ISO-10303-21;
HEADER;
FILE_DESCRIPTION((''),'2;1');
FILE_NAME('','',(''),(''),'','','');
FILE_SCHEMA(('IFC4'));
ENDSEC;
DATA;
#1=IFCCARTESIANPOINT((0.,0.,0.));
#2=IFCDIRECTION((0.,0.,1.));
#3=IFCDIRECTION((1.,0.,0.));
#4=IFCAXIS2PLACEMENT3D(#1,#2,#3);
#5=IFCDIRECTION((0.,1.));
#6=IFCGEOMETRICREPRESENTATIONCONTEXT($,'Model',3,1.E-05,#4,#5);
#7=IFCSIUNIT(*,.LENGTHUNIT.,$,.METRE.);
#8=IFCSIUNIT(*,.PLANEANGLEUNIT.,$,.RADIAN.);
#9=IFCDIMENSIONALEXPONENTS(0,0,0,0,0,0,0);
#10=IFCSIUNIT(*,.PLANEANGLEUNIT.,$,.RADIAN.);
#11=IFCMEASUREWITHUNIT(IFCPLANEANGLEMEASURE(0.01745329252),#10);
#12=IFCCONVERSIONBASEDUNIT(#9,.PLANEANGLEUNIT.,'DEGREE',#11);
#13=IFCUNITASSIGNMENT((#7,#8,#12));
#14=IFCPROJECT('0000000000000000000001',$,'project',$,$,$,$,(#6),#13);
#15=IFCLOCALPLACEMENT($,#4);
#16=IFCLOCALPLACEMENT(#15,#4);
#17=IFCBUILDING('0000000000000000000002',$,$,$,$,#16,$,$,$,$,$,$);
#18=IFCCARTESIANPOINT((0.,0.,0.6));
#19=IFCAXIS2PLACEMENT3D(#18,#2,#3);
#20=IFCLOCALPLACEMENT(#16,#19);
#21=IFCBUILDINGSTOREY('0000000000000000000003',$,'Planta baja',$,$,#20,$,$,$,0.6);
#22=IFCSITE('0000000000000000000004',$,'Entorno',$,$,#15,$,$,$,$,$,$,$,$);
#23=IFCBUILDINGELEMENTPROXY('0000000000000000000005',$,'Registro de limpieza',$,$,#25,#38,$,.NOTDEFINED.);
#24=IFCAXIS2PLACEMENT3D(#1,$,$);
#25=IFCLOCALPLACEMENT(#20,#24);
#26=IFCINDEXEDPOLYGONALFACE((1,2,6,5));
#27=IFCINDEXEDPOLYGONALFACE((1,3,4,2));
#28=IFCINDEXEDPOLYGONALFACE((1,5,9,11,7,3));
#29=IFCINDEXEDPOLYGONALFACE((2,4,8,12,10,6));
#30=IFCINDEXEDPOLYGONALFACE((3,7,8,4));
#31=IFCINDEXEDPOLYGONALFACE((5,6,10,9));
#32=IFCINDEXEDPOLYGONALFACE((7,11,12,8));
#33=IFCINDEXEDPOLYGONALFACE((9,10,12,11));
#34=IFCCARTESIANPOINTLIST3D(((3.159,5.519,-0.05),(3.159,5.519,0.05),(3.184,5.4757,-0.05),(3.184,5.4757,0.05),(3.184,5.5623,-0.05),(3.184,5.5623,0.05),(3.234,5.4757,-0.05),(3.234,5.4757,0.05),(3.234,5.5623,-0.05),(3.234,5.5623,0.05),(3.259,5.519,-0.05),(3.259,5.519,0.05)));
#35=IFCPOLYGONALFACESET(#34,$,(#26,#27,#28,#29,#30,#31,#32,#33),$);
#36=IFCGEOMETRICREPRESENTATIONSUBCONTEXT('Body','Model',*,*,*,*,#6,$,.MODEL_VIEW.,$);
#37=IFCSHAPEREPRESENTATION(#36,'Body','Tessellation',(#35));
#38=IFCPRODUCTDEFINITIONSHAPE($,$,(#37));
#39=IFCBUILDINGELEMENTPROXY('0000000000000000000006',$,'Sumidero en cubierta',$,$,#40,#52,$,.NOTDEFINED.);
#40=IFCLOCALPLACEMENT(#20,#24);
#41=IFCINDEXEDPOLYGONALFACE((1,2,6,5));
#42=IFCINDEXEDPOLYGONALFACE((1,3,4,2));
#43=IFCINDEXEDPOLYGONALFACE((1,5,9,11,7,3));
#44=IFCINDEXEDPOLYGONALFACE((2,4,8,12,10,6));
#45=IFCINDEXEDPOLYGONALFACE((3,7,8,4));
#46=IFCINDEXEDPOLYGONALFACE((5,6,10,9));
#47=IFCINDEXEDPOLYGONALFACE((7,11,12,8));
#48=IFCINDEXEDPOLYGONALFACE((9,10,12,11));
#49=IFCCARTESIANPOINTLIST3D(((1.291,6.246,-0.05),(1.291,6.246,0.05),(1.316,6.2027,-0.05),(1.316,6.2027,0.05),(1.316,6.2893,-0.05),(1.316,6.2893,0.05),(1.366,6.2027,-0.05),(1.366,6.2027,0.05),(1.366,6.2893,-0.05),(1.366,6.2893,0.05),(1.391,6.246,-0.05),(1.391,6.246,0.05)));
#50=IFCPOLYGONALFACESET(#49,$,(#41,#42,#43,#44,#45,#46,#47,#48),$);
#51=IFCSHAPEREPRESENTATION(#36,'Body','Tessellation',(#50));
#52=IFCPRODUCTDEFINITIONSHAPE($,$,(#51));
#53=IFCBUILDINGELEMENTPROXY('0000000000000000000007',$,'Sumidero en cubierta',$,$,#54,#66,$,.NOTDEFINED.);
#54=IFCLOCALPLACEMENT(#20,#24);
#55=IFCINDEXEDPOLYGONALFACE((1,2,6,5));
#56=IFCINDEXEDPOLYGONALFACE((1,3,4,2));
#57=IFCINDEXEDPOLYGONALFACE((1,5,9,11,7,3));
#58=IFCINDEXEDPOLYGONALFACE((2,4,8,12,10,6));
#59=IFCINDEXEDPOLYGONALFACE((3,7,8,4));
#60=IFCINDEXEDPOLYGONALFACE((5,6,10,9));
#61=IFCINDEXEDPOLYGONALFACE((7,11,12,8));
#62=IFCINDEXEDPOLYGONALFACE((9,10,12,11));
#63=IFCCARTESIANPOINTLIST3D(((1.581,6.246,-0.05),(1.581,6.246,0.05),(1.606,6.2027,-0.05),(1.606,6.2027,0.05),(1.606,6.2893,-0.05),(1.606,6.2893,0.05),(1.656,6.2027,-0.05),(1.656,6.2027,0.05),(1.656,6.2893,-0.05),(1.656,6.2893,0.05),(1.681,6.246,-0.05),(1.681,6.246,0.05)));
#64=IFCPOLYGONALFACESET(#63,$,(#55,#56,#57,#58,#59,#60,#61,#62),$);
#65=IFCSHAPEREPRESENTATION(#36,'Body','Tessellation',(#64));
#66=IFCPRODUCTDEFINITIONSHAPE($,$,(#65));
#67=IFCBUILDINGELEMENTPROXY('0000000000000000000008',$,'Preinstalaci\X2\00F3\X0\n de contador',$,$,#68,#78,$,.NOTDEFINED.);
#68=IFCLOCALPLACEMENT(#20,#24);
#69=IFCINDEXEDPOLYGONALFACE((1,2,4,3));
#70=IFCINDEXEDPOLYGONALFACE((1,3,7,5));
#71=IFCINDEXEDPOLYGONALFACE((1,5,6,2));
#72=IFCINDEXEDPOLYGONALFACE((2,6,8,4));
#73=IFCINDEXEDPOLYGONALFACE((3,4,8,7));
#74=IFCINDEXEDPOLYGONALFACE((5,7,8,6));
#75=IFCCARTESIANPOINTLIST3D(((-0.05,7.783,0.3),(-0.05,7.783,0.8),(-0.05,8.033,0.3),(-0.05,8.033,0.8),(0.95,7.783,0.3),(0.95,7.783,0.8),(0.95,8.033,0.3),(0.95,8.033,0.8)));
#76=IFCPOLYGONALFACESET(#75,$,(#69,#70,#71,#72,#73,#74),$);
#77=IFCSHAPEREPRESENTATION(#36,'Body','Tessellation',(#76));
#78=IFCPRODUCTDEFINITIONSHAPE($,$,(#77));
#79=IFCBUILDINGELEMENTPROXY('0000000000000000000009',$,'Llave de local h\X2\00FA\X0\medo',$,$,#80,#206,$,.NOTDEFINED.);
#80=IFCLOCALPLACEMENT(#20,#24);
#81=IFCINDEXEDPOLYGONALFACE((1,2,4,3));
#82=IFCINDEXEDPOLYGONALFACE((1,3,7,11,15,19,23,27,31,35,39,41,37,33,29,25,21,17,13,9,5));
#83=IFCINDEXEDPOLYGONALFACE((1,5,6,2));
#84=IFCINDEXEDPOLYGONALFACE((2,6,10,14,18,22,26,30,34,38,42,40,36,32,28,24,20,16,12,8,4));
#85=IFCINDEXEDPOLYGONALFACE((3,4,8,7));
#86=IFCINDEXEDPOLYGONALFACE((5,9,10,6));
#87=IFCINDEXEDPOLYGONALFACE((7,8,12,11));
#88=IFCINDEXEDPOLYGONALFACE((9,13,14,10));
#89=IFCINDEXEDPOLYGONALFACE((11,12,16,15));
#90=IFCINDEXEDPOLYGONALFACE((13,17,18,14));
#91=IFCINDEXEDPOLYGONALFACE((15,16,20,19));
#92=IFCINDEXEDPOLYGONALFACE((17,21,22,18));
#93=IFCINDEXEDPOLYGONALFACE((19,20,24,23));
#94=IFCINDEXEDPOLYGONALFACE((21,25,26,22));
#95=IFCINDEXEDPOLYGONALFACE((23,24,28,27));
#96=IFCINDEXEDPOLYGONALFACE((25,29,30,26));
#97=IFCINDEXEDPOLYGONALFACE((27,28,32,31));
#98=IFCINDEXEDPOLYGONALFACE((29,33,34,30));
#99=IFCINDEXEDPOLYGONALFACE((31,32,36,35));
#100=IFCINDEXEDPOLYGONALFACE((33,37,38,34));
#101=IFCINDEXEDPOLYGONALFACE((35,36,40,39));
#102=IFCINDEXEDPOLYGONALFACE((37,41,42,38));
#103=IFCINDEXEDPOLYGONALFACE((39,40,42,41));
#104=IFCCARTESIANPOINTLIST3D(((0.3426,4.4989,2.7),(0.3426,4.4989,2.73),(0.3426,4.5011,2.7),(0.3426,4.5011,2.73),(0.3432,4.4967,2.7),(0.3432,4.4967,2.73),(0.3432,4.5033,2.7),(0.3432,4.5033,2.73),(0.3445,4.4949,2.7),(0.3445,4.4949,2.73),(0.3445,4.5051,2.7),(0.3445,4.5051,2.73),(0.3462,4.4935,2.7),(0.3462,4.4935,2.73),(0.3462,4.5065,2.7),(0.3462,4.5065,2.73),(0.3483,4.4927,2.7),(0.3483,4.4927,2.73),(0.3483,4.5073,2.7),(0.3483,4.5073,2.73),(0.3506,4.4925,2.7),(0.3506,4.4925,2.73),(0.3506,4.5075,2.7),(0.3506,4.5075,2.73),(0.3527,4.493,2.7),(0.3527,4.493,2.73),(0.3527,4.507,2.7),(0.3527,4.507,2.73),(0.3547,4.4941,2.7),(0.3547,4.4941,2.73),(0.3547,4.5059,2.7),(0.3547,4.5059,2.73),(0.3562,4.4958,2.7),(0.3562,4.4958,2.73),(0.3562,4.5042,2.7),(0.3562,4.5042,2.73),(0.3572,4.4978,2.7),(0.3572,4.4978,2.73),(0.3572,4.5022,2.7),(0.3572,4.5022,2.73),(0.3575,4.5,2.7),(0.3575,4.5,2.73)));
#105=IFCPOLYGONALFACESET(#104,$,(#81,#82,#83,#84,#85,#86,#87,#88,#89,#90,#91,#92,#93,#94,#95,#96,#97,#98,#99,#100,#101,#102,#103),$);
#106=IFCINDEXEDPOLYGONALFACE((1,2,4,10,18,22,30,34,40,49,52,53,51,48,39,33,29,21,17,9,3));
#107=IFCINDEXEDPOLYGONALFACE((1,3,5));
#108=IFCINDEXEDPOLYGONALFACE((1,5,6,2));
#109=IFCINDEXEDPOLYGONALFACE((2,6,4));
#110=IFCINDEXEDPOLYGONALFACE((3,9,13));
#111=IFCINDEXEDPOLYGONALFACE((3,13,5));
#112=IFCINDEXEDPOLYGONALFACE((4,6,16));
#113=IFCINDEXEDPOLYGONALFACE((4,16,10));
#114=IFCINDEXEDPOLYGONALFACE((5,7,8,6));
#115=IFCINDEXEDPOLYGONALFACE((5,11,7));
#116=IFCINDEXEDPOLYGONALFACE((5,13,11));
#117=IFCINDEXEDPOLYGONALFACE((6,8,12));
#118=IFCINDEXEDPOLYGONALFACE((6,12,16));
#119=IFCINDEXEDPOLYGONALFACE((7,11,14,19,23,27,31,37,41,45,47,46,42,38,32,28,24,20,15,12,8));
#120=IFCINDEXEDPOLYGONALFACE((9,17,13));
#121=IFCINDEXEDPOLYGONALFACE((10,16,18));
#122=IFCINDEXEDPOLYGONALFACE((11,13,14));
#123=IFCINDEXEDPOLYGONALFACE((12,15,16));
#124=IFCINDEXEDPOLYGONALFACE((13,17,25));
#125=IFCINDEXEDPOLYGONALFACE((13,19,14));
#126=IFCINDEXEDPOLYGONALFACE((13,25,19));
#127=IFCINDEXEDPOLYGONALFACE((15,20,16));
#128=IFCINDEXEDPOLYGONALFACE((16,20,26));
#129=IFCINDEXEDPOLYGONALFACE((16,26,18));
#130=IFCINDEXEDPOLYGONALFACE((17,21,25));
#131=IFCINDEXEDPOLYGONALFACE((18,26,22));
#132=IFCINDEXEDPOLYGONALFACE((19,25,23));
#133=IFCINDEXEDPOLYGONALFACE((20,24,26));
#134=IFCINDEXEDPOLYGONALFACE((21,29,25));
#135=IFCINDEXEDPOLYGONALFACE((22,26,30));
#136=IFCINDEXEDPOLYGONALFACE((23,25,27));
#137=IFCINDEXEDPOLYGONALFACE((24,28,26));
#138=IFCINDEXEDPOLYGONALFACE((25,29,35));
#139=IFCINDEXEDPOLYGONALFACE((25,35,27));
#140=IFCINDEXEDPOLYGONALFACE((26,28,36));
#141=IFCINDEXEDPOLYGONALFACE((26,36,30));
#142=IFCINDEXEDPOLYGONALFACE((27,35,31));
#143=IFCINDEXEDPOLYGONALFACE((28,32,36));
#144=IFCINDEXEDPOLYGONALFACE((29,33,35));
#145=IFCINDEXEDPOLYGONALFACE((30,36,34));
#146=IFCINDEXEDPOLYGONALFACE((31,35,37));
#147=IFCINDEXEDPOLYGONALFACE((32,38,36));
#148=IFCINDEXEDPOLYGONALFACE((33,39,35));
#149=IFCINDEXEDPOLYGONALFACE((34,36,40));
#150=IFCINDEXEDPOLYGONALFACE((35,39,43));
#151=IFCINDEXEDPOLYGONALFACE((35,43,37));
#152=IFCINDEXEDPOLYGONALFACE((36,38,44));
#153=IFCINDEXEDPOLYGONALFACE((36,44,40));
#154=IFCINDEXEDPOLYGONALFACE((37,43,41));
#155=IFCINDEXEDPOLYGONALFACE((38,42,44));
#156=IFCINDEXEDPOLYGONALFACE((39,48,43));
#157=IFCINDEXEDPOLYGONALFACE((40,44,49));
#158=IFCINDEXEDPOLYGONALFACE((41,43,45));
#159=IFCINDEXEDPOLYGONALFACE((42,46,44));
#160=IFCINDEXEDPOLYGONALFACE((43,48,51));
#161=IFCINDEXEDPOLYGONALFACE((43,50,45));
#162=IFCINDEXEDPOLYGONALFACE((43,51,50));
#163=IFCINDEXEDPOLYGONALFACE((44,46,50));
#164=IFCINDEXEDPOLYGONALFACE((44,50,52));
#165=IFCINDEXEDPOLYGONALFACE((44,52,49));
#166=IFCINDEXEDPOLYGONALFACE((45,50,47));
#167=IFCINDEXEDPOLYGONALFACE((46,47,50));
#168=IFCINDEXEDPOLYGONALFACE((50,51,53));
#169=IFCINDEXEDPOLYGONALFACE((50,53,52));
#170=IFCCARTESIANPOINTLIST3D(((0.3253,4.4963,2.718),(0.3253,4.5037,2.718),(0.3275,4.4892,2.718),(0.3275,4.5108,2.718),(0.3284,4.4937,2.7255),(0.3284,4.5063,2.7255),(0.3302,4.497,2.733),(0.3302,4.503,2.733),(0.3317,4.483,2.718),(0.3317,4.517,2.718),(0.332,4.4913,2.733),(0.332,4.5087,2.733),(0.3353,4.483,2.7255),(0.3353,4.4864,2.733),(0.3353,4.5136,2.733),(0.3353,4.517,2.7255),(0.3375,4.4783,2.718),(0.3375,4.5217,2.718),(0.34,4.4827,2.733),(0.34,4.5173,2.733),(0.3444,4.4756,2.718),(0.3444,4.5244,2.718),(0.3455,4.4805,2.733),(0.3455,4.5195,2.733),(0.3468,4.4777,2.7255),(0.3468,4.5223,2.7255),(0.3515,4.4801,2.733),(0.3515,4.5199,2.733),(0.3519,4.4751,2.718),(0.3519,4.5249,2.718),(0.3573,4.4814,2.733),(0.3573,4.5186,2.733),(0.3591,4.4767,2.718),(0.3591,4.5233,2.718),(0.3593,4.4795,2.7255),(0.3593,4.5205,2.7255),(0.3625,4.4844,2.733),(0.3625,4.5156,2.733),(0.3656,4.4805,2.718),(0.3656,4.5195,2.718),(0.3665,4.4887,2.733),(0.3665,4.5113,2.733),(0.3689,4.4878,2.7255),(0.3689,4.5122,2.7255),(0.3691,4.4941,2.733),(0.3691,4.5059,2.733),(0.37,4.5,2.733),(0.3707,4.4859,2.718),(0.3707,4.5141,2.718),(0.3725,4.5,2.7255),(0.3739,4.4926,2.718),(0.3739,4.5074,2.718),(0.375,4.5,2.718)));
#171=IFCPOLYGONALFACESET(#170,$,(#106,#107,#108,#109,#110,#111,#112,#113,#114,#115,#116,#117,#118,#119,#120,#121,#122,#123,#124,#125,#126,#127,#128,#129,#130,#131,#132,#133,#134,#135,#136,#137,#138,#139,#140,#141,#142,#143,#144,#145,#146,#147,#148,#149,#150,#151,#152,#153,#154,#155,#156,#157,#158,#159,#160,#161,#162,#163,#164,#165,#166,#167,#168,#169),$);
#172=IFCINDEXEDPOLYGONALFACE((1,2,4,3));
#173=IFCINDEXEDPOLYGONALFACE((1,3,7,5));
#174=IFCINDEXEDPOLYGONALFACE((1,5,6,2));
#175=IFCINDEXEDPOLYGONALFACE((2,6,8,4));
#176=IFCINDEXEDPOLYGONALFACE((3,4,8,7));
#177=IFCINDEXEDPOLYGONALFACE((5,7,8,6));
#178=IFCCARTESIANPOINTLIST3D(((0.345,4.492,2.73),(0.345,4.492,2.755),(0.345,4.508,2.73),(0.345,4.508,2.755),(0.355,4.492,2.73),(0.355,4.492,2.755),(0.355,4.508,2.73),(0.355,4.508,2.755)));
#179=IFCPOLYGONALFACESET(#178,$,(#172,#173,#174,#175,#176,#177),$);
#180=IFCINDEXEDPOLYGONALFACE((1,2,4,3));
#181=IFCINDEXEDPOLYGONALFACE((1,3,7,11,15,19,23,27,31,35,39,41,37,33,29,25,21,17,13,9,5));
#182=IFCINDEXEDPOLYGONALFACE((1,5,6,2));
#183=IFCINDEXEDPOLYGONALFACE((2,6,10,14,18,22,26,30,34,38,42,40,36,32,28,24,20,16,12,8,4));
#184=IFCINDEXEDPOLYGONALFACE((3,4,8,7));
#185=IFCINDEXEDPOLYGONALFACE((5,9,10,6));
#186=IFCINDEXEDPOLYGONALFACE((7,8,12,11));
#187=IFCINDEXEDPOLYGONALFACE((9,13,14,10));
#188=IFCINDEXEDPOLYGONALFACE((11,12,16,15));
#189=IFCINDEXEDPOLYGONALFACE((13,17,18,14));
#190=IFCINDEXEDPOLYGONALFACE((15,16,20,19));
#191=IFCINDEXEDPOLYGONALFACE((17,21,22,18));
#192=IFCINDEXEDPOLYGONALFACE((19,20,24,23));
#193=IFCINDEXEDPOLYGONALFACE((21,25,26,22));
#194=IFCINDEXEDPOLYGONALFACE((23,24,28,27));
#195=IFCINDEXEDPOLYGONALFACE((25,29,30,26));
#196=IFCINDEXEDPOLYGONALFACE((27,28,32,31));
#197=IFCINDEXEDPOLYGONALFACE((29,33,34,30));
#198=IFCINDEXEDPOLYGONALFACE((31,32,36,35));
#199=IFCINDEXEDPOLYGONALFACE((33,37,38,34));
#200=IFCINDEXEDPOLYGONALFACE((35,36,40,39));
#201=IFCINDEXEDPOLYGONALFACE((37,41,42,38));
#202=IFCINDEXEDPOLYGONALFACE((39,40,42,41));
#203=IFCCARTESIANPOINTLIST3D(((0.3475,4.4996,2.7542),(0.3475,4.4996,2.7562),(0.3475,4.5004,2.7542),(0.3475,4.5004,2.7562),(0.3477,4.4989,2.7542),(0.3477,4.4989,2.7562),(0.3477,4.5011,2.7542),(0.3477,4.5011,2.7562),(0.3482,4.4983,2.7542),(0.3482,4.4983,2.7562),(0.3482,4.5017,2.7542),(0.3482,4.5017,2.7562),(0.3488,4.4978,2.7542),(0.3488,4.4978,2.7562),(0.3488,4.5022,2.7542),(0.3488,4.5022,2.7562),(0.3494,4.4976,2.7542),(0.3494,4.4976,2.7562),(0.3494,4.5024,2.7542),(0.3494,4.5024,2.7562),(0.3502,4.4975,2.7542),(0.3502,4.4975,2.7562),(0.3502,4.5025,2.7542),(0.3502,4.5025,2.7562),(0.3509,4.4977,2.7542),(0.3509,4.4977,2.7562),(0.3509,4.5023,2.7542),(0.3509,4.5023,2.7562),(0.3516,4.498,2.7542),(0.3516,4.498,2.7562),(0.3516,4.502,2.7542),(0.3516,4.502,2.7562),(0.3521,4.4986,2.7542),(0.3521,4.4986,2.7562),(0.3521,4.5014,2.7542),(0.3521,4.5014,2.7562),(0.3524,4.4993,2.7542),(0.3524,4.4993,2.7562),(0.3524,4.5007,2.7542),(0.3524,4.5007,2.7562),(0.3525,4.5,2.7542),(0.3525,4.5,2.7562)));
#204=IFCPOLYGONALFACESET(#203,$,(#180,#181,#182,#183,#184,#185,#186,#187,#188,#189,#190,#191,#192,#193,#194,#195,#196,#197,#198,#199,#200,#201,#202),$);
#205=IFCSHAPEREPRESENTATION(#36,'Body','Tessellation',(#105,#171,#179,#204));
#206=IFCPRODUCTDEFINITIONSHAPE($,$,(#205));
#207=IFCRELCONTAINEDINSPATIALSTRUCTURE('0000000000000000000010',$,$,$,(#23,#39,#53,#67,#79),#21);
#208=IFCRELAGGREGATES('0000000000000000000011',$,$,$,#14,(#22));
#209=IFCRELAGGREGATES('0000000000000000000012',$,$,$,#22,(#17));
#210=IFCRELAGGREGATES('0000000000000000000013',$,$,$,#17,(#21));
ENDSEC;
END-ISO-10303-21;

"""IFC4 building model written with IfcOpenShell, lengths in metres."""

from ifc_helpers import new_model, entity, si_unit, converted_unit, direction, frame, origin_with_axes, place, context, subcontext, project, spatial, polyline, outline, extrude, source, transform, mapped, element, save


model = new_model("IFC4")

# Units and contexts
model_context = context("Model", 3, precision=1e-05, world=origin_with_axes(), true_north=direction((0.0, 1.0)))
body_context = subcontext(model_context, "Body", "Model", "MODEL_VIEW")
ifc_project = project(units=[si_unit("LENGTHUNIT", "METRE"), si_unit("PLANEANGLEUNIT", "RADIAN"), converted_unit("PLANEANGLEUNIT", "DEGREE", entity("IfcPlaneAngleMeasure", 0.01745329252), si_unit("PLANEANGLEUNIT", "RADIAN"), dimensions=[0, 0, 0, 0, 0, 0, 0])], contexts=[model_context])

# Site, building, storey
site_placement = place(None, origin_with_axes())
site = spatial("IfcSite", under=ifc_project, at=site_placement, Name="Entorno")
building_placement = place(site_placement, origin_with_axes())
building = spatial("IfcBuilding", under=site, at=building_placement)
storey_placement = place(building_placement, frame((0.0, 0.0, 0.6), z_axis=(0.0, 0.0, 1.0), x_axis=(1.0, 0.0, 0.0)))
storey = spatial("IfcBuildingStorey", under=building, at=storey_placement, Name="Planta baja", Elevation=0.6)

# Building element proxies
shared_shape_1 = source(origin_with_axes(), body_context, "Body", "SolidModel", [
    extrude(outline(polyline([(0.05, 0.0), (0.025, 0.0433), (-0.025, 0.0433), (-0.05, 0.0), (-0.025, -0.0433), (0.025, -0.0433), (0.05, 0.0)])), frame((0.0, 0.0, -0.05), z_axis=(0.0, 0.0, 1.0), x_axis=(1.0, 0.0, 0.0)), (0.0, 0.0, 1.0), 0.1),
])
proxy_1_placement = place(storey_placement, frame((0.0, 0.0, -0.6), z_axis=(0.0, 0.0, 1.0), x_axis=(1.0, 0.0, 0.0)))
element("IfcBuildingElementProxy", 1, at=proxy_1_placement, inside=storey, Name="Registro de limpieza", PredefinedType="NOTDEFINED", context=body_context, shape_type="Brep", body=[
    mapped(shared_shape_1, transform((3.209, 5.519, 0.6), x_axis=(1.0, 0.0, 0.0), y_axis=(0.0, 1.0, 0.0), z_axis=(0.0, 0.0, 1.0))),
])
shared_shape_2 = source(origin_with_axes(), body_context, "Body", "SolidModel", [
    extrude(outline(polyline([(0.05, 0.0), (0.025, 0.0433), (-0.025, 0.0433), (-0.05, 0.0), (-0.025, -0.0433), (0.025, -0.0433), (0.05, 0.0)])), frame((0.0, 0.0, -0.05), z_axis=(0.0, 0.0, 1.0), x_axis=(1.0, 0.0, 0.0)), (0.0, 0.0, 1.0), 0.1),
])
proxy_2_placement = place(storey_placement, frame((0.0, 0.0, -0.6), z_axis=(0.0, 0.0, 1.0), x_axis=(1.0, 0.0, 0.0)))
element("IfcBuildingElementProxy", 2, at=proxy_2_placement, inside=storey, Name="Sumidero en cubierta", PredefinedType="NOTDEFINED", context=body_context, shape_type="Brep", body=[
    mapped(shared_shape_2, transform((1.341, 6.246, 0.6), x_axis=(1.0, 0.0, 0.0), y_axis=(0.0, 1.0, 0.0), z_axis=(0.0, 0.0, 1.0))),
])
proxy_3_placement = place(storey_placement, frame((0.0, 0.0, -0.6), z_axis=(0.0, 0.0, 1.0), x_axis=(1.0, 0.0, 0.0)))
element("IfcBuildingElementProxy", 3, at=proxy_3_placement, inside=storey, Name="Sumidero en cubierta", PredefinedType="NOTDEFINED", context=body_context, shape_type="Brep", body=[
    mapped(shared_shape_2, transform((1.631, 6.246, 0.6), x_axis=(1.0, 0.0, 0.0), y_axis=(0.0, 1.0, 0.0), z_axis=(0.0, 0.0, 1.0))),
])
proxy_4_placement = place(storey_placement, frame((0.0, 0.0, -0.6), z_axis=(0.0, 0.0, 1.0), x_axis=(1.0, 0.0, 0.0)))
element("IfcBuildingElementProxy", 4, at=proxy_4_placement, inside=storey, Name="Preinstalación de contador", PredefinedType="NOTDEFINED", context=body_context, shape_type="Brep", body=[
    extrude(outline(polyline([(0.0, -0.125), (1.0, -0.125), (1.0, 0.125), (0.0, 0.125), (0.0, -0.125)])), frame((-0.05, 7.908, 0.9), z_axis=(0.0, 0.0, 1.0), x_axis=(1.0, 0.0, 0.0)), (0.0, 0.0, 1.0), 0.5),
])
proxy_5_placement = place(storey_placement, frame((0.0, 0.0, -0.6), z_axis=(0.0, 0.0, 1.0), x_axis=(1.0, 0.0, 0.0)))
ifc_direction_1 = entity("IfcDirection", [0.0, 0.0, 1.0])
ifc_direction_2 = entity("IfcDirection", [0.0, 0.0, 1.0])
ifc_direction_3 = entity("IfcDirection", [0.0, 0.0, 1.0])
element("IfcBuildingElementProxy", 5, at=proxy_5_placement, inside=storey, Name="Llave de local húmedo", PredefinedType="NOTDEFINED", context=body_context, shape_type="Brep", body=[
    entity("IfcExtrudedAreaSolidTapered", entity("IfcCircleProfileDef", "AREA", None, entity("IfcAxis2Placement2D", entity("IfcCartesianPoint", [0.0, 0.0]), entity("IfcDirection", [1.0, 0.0])), 0.0075), entity("IfcAxis2Placement3D", entity("IfcCartesianPoint", [0.35, 4.5, 3.3]), ifc_direction_1, entity("IfcDirection", [1.0, 0.0, 0.0])), ifc_direction_1, 0.03, entity("IfcCircleProfileDef", "AREA", None, entity("IfcAxis2Placement2D", entity("IfcCartesianPoint", [0.0, 0.0]), entity("IfcDirection", [1.0, 0.0])), 0.0075)),
    entity("IfcExtrudedAreaSolidTapered", entity("IfcCircleProfileDef", "AREA", None, entity("IfcAxis2Placement2D", entity("IfcCartesianPoint", [0.0, 0.0]), entity("IfcDirection", [1.0, 0.0])), 0.025), entity("IfcAxis2Placement3D", entity("IfcCartesianPoint", [0.35, 4.5, 3.318]), ifc_direction_2, entity("IfcDirection", [1.0, 0.0, 0.0])), ifc_direction_2, 0.015, entity("IfcCircleProfileDef", "AREA", None, entity("IfcAxis2Placement2D", entity("IfcCartesianPoint", [0.0, 0.0]), entity("IfcDirection", [1.0, 0.0])), 0.02)),
    extrude(outline(polyline([(0.005, -0.008), (0.005, 0.008), (-0.005, 0.008), (-0.005, -0.008), (0.005, -0.008)])), frame((0.35, 4.5, 3.33), z_axis=(0.0, 0.0, 1.0), x_axis=(1.0, 0.0, 0.0)), (0.0, 0.0, 1.0), 0.025),
    entity("IfcExtrudedAreaSolidTapered", entity("IfcCircleProfileDef", "AREA", None, entity("IfcAxis2Placement2D", entity("IfcCartesianPoint", [0.0, 0.0]), entity("IfcDirection", [1.0, 0.0])), 0.0025), entity("IfcAxis2Placement3D", entity("IfcCartesianPoint", [0.35, 4.5, 3.3542]), ifc_direction_3, entity("IfcDirection", [1.0, 0.0, 0.0])), ifc_direction_3, 0.002, entity("IfcCircleProfileDef", "AREA", None, entity("IfcAxis2Placement2D", entity("IfcCartesianPoint", [0.0, 0.0]), entity("IfcDirection", [1.0, 0.0])), 0.0025)),
])

save(model, "model.ifc")
